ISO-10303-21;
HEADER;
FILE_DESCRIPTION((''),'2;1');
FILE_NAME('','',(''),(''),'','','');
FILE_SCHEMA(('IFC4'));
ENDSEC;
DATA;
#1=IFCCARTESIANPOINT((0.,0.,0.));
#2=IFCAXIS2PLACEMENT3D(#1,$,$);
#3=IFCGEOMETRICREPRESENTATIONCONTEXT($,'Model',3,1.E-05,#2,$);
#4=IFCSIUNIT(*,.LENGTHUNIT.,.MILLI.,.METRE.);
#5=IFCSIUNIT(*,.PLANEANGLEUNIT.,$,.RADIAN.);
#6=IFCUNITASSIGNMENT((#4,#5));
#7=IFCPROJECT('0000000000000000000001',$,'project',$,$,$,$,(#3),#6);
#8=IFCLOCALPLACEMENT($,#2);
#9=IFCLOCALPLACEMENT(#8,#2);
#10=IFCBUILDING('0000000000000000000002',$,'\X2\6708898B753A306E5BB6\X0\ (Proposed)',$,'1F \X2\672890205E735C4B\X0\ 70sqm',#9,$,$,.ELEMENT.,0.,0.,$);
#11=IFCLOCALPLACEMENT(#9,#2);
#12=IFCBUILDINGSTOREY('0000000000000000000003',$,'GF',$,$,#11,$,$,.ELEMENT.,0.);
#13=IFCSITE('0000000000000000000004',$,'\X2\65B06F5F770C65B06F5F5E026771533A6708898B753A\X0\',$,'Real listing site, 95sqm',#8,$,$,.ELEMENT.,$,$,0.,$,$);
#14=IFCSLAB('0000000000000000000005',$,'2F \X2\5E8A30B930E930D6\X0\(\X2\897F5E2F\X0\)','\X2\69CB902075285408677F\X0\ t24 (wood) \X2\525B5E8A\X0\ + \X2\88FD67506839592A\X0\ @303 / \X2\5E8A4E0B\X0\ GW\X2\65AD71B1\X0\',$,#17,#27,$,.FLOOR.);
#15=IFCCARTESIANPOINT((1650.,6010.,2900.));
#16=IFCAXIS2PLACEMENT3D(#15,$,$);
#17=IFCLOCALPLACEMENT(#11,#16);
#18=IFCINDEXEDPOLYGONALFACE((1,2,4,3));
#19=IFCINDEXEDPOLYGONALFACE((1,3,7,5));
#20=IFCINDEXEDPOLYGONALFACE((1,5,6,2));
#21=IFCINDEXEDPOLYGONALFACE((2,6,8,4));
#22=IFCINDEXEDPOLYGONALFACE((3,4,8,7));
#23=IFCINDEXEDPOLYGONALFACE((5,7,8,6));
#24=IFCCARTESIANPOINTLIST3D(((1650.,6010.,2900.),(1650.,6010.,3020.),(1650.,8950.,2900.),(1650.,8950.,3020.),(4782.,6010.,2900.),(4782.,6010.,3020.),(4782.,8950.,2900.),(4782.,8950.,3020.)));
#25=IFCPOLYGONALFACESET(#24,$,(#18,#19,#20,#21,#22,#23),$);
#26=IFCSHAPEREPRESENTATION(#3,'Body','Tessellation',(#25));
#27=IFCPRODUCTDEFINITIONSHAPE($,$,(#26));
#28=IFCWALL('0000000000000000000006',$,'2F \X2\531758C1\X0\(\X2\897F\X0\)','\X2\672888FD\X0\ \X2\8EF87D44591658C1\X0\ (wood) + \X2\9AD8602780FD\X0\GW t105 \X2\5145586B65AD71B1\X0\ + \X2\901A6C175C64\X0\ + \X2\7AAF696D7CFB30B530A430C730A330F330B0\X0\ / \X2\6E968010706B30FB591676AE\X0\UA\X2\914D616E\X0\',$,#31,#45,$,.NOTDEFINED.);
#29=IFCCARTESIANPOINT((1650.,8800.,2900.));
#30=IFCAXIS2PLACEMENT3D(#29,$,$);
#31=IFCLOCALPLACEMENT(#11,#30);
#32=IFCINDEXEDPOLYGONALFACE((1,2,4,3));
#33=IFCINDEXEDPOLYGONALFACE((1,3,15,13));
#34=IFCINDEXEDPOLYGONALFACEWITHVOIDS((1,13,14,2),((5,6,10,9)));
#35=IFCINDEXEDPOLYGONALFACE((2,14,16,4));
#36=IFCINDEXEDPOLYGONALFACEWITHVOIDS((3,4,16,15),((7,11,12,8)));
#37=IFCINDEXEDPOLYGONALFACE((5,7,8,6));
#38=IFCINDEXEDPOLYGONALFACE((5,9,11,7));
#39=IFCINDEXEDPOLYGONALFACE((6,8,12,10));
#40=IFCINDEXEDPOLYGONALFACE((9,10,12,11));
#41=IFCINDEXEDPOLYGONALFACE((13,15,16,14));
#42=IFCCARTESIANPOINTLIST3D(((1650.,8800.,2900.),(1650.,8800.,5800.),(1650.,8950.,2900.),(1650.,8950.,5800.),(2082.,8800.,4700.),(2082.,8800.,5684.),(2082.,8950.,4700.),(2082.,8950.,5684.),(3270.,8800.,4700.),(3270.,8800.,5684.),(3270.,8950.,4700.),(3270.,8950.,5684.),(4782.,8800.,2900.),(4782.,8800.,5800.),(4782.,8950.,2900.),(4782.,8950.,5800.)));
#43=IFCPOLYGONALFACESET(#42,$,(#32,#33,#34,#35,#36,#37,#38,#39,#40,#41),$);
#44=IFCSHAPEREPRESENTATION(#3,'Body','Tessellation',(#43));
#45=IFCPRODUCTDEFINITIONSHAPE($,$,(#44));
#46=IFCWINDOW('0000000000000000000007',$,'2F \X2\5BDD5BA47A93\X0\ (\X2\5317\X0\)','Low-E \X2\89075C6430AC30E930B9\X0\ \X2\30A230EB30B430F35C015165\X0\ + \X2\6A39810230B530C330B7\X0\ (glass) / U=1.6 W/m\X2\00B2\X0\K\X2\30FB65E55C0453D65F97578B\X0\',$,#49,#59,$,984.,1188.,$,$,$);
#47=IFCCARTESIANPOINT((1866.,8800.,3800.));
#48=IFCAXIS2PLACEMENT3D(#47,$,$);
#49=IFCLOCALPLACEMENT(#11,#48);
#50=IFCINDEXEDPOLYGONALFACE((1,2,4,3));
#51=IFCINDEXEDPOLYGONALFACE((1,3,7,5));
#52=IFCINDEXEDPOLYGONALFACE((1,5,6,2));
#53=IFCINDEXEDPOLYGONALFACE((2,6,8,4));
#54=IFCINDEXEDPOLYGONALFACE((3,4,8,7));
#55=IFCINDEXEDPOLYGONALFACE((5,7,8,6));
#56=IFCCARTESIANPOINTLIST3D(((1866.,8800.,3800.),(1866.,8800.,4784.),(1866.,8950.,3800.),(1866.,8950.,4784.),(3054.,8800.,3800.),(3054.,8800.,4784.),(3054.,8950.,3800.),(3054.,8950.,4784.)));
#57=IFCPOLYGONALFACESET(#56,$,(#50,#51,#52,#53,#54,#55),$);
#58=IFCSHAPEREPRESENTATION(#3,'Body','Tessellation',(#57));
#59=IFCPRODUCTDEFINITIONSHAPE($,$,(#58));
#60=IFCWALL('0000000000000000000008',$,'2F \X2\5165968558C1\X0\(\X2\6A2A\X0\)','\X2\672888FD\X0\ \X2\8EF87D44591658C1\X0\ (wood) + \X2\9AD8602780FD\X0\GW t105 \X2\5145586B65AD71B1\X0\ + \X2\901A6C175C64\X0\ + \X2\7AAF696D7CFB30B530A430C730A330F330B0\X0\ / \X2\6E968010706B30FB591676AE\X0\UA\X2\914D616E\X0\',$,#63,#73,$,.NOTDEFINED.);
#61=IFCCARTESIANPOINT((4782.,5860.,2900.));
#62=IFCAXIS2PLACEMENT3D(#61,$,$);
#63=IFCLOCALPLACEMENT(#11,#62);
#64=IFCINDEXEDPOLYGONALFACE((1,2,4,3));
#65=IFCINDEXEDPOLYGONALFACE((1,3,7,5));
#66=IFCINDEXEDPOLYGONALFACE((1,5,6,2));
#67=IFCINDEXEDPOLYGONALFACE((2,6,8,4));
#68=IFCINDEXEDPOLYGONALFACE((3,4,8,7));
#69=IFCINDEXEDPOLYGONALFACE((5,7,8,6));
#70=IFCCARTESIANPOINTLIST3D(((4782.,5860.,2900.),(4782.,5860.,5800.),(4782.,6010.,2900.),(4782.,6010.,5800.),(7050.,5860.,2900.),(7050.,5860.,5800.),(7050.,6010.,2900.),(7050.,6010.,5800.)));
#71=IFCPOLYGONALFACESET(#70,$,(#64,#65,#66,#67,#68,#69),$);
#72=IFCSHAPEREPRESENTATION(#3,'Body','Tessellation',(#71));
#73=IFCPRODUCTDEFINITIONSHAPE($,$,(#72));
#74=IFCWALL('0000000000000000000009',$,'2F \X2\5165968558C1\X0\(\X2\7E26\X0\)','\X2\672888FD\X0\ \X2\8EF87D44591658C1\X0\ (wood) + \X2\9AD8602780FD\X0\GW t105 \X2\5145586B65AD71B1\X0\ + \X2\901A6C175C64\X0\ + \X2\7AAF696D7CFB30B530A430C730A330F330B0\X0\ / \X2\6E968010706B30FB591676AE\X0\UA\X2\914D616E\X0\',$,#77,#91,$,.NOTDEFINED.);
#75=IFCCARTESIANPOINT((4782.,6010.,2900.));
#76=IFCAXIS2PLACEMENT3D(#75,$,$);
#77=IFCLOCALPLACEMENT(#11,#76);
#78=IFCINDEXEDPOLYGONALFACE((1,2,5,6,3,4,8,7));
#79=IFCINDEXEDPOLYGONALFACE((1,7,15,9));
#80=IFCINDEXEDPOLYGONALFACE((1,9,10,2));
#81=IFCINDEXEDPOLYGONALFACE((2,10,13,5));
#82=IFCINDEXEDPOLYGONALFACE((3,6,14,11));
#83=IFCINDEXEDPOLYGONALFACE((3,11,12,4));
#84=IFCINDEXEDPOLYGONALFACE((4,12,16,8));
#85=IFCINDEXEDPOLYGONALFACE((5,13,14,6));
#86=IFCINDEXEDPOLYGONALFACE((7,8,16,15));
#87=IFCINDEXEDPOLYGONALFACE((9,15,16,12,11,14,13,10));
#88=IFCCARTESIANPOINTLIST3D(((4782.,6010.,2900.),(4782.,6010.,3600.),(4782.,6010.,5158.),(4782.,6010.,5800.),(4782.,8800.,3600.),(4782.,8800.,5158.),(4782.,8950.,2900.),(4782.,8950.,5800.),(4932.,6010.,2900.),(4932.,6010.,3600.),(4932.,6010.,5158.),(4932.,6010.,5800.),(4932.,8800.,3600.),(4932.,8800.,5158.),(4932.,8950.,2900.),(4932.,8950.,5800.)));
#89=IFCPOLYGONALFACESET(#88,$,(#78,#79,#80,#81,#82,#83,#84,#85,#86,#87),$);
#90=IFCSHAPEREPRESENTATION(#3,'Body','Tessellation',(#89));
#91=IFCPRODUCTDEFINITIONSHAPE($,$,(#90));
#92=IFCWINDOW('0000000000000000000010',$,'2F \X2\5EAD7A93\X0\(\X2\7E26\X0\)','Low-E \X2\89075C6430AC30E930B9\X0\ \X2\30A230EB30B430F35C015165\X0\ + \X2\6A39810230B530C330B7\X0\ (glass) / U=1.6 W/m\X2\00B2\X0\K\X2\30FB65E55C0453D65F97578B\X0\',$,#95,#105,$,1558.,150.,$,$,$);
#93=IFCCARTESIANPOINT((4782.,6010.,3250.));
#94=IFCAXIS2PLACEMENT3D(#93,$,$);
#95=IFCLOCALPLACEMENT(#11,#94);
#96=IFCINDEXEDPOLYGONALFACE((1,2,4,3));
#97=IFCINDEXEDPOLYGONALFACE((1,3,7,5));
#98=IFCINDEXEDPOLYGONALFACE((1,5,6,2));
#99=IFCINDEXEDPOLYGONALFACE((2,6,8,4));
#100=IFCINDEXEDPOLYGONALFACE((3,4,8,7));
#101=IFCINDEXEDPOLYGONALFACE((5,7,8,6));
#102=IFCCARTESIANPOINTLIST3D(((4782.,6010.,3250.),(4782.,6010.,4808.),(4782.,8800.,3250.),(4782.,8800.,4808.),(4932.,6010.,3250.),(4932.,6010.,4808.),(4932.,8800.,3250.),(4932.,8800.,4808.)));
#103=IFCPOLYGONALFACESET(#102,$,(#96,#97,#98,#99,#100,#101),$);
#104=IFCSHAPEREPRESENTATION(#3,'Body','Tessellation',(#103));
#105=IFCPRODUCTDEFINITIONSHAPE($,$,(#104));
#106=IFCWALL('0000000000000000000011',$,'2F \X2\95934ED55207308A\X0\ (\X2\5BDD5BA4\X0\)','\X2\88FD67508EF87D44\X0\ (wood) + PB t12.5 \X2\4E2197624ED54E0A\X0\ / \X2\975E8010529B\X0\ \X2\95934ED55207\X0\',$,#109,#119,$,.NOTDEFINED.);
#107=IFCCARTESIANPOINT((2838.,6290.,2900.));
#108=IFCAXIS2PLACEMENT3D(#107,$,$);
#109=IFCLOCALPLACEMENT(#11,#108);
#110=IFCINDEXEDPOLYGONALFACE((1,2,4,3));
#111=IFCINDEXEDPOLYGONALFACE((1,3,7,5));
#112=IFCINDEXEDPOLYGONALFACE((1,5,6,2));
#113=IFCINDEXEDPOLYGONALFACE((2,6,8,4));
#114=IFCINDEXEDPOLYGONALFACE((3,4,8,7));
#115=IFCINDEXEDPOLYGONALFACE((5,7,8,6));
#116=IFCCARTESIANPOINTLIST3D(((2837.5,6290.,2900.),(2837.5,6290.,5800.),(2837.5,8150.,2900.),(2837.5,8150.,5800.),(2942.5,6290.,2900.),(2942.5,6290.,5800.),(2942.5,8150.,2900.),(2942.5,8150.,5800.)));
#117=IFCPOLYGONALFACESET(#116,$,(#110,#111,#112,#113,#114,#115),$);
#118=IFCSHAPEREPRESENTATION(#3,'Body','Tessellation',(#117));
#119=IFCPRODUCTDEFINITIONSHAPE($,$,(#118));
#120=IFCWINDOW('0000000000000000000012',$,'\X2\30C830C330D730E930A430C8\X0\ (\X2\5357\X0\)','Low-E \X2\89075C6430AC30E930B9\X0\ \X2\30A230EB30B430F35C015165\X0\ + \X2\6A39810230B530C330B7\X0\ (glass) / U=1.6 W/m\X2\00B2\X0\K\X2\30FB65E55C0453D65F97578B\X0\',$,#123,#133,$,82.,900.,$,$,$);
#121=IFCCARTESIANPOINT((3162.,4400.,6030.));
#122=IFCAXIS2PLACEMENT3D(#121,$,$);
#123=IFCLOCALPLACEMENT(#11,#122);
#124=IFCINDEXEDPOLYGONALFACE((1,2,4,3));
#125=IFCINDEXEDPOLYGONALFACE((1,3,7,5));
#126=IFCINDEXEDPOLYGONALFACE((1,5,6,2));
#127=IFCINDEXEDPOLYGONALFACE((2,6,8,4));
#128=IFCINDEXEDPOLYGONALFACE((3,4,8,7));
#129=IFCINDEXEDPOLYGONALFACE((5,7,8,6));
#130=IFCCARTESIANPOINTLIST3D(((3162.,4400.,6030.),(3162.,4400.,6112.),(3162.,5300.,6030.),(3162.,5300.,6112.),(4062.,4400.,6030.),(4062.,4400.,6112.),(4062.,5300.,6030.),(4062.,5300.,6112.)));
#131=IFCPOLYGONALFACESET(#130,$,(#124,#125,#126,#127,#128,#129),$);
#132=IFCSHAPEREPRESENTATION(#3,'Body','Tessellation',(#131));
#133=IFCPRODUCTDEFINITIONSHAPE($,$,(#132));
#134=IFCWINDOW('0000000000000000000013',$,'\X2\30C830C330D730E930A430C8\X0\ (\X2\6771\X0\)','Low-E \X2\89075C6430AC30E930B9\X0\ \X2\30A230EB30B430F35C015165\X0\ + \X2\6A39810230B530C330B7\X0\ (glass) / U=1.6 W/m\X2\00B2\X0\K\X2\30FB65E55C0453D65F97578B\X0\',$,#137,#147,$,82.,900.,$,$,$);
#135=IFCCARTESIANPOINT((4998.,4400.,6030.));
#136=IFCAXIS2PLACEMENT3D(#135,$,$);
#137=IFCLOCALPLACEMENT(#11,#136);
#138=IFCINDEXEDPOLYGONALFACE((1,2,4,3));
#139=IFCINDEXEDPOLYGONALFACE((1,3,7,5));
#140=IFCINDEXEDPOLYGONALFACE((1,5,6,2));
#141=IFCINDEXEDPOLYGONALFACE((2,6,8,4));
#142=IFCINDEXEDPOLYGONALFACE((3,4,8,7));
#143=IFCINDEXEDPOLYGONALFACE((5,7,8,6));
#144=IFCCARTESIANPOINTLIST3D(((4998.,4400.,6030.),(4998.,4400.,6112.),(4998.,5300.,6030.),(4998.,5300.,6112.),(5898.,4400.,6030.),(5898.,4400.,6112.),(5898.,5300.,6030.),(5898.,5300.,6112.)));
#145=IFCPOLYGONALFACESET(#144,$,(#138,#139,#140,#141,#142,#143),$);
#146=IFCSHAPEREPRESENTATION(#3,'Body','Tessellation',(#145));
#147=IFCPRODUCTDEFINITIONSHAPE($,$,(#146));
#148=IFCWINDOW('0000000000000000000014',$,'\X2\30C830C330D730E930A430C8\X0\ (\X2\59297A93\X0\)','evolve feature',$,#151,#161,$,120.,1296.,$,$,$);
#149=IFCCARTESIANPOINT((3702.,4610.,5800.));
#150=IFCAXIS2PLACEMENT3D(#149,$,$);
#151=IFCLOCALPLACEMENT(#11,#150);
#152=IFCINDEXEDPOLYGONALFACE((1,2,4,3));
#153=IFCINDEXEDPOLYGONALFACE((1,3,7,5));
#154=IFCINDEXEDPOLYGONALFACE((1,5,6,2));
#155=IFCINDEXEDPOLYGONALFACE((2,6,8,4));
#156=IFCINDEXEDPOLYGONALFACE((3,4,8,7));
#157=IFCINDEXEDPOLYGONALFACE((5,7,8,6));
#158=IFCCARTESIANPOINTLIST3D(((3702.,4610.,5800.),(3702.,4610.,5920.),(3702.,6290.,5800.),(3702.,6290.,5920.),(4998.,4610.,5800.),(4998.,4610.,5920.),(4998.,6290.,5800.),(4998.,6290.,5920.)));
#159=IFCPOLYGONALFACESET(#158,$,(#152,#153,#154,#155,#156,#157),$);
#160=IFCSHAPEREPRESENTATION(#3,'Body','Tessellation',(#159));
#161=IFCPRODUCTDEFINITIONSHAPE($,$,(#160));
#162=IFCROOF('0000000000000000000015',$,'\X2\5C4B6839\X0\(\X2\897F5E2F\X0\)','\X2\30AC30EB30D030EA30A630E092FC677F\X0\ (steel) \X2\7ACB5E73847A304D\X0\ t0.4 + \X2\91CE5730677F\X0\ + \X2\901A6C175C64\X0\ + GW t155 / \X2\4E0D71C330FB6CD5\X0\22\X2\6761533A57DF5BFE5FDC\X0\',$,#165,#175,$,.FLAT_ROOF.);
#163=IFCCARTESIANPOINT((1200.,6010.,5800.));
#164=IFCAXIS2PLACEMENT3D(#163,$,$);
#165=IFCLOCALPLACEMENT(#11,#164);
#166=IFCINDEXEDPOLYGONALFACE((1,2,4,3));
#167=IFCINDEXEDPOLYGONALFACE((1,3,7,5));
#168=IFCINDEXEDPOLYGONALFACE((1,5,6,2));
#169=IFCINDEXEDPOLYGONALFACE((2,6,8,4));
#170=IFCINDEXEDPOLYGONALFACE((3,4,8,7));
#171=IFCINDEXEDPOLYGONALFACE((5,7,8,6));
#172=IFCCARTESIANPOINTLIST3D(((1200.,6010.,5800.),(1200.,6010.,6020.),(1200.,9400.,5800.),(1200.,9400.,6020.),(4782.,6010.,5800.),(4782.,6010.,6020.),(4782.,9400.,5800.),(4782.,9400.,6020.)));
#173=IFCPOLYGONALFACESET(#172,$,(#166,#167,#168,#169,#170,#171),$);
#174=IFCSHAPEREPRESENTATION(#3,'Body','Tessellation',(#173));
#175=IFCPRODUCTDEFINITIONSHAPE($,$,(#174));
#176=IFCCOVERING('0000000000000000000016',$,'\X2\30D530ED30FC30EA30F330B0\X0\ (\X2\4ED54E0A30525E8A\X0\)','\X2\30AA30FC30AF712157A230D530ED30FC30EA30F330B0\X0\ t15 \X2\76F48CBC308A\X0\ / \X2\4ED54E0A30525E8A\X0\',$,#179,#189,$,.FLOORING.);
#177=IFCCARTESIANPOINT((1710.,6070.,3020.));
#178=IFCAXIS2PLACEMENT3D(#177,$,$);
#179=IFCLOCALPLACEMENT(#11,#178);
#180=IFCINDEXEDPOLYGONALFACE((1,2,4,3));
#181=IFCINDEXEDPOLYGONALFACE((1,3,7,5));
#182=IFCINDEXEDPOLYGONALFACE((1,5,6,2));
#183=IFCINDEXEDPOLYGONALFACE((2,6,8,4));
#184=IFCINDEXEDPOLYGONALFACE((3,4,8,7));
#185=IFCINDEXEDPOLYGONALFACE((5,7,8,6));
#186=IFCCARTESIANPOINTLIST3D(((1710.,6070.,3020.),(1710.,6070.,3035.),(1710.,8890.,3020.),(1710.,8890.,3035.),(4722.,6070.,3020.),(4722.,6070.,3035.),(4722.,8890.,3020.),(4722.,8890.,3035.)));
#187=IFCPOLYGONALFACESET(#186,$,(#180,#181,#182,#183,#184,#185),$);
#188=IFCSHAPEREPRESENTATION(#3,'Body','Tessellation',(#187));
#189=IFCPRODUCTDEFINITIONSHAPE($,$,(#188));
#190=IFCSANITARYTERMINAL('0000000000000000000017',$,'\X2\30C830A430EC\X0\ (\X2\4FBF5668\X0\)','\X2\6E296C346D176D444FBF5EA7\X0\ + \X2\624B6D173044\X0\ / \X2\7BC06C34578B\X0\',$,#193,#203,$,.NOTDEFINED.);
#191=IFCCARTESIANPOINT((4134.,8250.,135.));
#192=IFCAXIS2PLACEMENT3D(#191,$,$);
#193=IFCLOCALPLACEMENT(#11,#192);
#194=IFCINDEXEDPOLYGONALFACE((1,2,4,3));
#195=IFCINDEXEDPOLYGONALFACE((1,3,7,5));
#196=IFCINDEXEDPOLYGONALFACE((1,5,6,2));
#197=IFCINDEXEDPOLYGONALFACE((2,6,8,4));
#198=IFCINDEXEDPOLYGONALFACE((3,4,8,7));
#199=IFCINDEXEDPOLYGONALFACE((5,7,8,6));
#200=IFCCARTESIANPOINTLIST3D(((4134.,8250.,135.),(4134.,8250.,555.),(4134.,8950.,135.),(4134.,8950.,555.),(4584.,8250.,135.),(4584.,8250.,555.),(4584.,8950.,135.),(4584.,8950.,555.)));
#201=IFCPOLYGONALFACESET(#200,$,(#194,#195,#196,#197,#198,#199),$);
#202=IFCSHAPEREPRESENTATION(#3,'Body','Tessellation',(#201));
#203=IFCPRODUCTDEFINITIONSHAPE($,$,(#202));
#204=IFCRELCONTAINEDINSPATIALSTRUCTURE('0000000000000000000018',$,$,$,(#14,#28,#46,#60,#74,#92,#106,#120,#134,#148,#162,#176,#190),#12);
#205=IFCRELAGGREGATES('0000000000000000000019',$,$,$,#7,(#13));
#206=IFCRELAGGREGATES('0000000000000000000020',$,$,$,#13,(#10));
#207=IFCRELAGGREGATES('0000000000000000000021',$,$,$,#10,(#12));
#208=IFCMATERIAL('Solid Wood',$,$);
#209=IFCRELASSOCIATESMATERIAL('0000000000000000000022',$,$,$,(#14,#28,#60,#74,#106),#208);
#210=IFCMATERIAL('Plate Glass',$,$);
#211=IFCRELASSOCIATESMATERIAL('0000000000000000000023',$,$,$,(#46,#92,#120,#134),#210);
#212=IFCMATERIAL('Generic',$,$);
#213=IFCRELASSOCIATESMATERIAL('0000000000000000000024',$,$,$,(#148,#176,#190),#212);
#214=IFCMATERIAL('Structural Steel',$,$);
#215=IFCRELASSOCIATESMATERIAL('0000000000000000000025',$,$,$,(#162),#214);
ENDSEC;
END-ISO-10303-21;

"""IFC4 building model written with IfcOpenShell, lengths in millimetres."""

from ifc_helpers import new_model, si_unit, frame, frame_2d, origin, place, context, project, spatial, rectangle, extrude, material, element, fill, save


model = new_model("IFC4")

# Units and contexts
model_context = context("Model", 3, precision=1e-05, world=origin())
ifc_project = project(units=[si_unit("LENGTHUNIT", "METRE", prefix="MILLI"), si_unit("PLANEANGLEUNIT", "RADIAN")], contexts=[model_context])

# Site, building, storey
site_placement = place(None, origin())
site = spatial("IfcSite", under=ifc_project, at=site_placement, Name="新潟県新潟市東区月見町", ObjectType="Real listing site, 95sqm", CompositionType="ELEMENT", RefElevation=0.0)
building_placement = place(site_placement, origin())
building = spatial("IfcBuilding", under=site, at=building_placement, Name="月見町の家 (Proposed)", ObjectType="1F 木造平屋 70sqm", CompositionType="ELEMENT", ElevationOfRefHeight=0.0, ElevationOfTerrain=0.0)
storey_placement = place(building_placement, origin())
storey = spatial("IfcBuildingStorey", under=building, at=storey_placement, Name="GF", CompositionType="ELEMENT", Elevation=0.0)

# Slab
ifc_material_1 = material(Name="Solid Wood")
slab_placement = place(storey_placement, frame((1650.0, 6010.0, 2900.0)))
element("IfcSlab", 1, at=slab_placement, inside=storey, material=ifc_material_1, Name="2F 床スラブ(西帯)", Description="構造用合板 t24 (wood) 剛床 + 製材根太 @303 / 床下 GW断熱", PredefinedType="FLOOR", context=model_context, shape_type="SweptSolid", body=[
    extrude(rectangle(XDim=3132.0, YDim=2940.0, at=frame_2d((1566.0, 1470.0))), frame((1650.0, 6010.0, 2900.0)), (0.0, 0.0, 1.0), 120.0),
])

# Wall, opening, window
wall_1_placement = place(storey_placement, frame((1650.0, 8800.0, 2900.0)))
wall_1 = element("IfcWall", 2, at=wall_1_placement, inside=storey, material=ifc_material_1, Name="2F 北壁(西)", Description="木製 軸組外壁 (wood) + 高性能GW t105 充填断熱 + 通気層 + 窯業系サイディング / 準耐火・外皮UA配慮", PredefinedType="NOTDEFINED", context=model_context, shape_type="SweptSolid", body=[
    extrude(rectangle(XDim=3132.0, YDim=150.0, at=frame_2d((1566.0, 75.0))), frame((1650.0, 8800.0, 2900.0)), (0.0, 0.0, 1.0), 2900.0),
])
opening_1_placement = place(storey_placement, frame((1866.0, 8800.0, 3800.0)))
opening_1 = element("IfcOpeningElement", 3, at=opening_1_placement, cuts=wall_1, PredefinedType="NOTDEFINED", context=model_context, shape_type="SweptSolid", body=[
    extrude(rectangle(XDim=1188.0, YDim=150.0, at=frame_2d((594.0, 75.0))), frame((1866.0, 8800.0, 3800.0)), (0.0, 0.0, 1.0), 984.0),
])
ifc_material_2 = material(Name="Plate Glass")
window_1_placement = place(storey_placement, frame((1866.0, 8800.0, 3800.0)))
window_1 = element("IfcWindow", 4, at=window_1_placement, inside=storey, material=ifc_material_2, Name="2F 寝室窓 (北)", Description="Low-E 複層ガラス アルゴン封入 + 樹脂サッシ (glass) / U=1.6 W/m²K・日射取得型", OverallHeight=984.0, OverallWidth=1188.0, context=model_context, shape_type="SweptSolid", body=[
    extrude(rectangle(XDim=1188.0, YDim=150.0, at=frame_2d((594.0, 75.0))), frame((1866.0, 8800.0, 3800.0)), (0.0, 0.0, 1.0), 984.0),
])
fill(opening_1, window_1)

# Wall
wall_2_placement = place(storey_placement, frame((4782.0, 5860.0, 2900.0)))
element("IfcWall", 5, at=wall_2_placement, inside=storey, material=ifc_material_1, Name="2F 入隅壁(横)", Description="木製 軸組外壁 (wood) + 高性能GW t105 充填断熱 + 通気層 + 窯業系サイディング / 準耐火・外皮UA配慮", PredefinedType="NOTDEFINED", context=model_context, shape_type="SweptSolid", body=[
    extrude(rectangle(XDim=2268.0, YDim=150.0, at=frame_2d((1134.0, 75.0))), frame((4782.0, 5860.0, 2900.0)), (0.0, 0.0, 1.0), 2900.0),
])

# Wall, opening, window
wall_3_placement = place(storey_placement, frame((4782.0, 6010.0, 2900.0)))
wall_3 = element("IfcWall", 6, at=wall_3_placement, inside=storey, material=ifc_material_1, Name="2F 入隅壁(縦)", Description="木製 軸組外壁 (wood) + 高性能GW t105 充填断熱 + 通気層 + 窯業系サイディング / 準耐火・外皮UA配慮", PredefinedType="NOTDEFINED", context=model_context, shape_type="SweptSolid", body=[
    extrude(rectangle(XDim=150.0, YDim=2940.0, at=frame_2d((75.0, 1470.0))), frame((4782.0, 6010.0, 2900.0)), (0.0, 0.0, 1.0), 2900.0),
])
opening_2_placement = place(storey_placement, frame((4782.0, 6010.0, 3250.0)))
opening_2 = element("IfcOpeningElement", 7, at=opening_2_placement, cuts=wall_3, PredefinedType="NOTDEFINED", context=model_context, shape_type="SweptSolid", body=[
    extrude(rectangle(XDim=150.0, YDim=2790.0, at=frame_2d((75.0, 1395.0))), frame((4782.0, 6010.0, 3250.0)), (0.0, 0.0, 1.0), 1558.0),
])
window_2_placement = place(storey_placement, frame((4782.0, 6010.0, 3250.0)))
window_2 = element("IfcWindow", 8, at=window_2_placement, inside=storey, material=ifc_material_2, Name="2F 庭窓(縦)", Description="Low-E 複層ガラス アルゴン封入 + 樹脂サッシ (glass) / U=1.6 W/m²K・日射取得型", OverallHeight=1558.0, OverallWidth=150.0, context=model_context, shape_type="SweptSolid", body=[
    extrude(rectangle(XDim=150.0, YDim=2790.0, at=frame_2d((75.0, 1395.0))), frame((4782.0, 6010.0, 3250.0)), (0.0, 0.0, 1.0), 1558.0),
])
fill(opening_2, window_2)

# Wall
wall_4_placement = place(storey_placement, frame((2838.0, 6290.0, 2900.0)))
element("IfcWall", 9, at=wall_4_placement, inside=storey, material=ifc_material_1, Name="2F 間仕切り (寝室)", Description="製材軸組 (wood) + PB t12.5 両面仕上 / 非耐力 間仕切", PredefinedType="NOTDEFINED", context=model_context, shape_type="SweptSolid", body=[
    extrude(rectangle(XDim=105.0, YDim=1860.0, at=frame_2d((52.0, 930.0))), frame((2838.0, 6290.0, 2900.0)), (0.0, 0.0, 1.0), 2900.0),
])

# Windows
window_3_placement = place(storey_placement, frame((3162.0, 4400.0, 6030.0)))
element("IfcWindow", 10, at=window_3_placement, inside=storey, material=ifc_material_2, Name="トップライト (南)", Description="Low-E 複層ガラス アルゴン封入 + 樹脂サッシ (glass) / U=1.6 W/m²K・日射取得型", OverallHeight=82.0, OverallWidth=900.0, context=model_context, shape_type="SweptSolid", body=[
    extrude(rectangle(XDim=900.0, YDim=900.0, at=frame_2d((450.0, 450.0))), frame((3162.0, 4400.0, 6030.0)), (0.0, 0.0, 1.0), 82.0),
])
window_4_placement = place(storey_placement, frame((4998.0, 4400.0, 6030.0)))
element("IfcWindow", 11, at=window_4_placement, inside=storey, material=ifc_material_2, Name="トップライト (東)", Description="Low-E 複層ガラス アルゴン封入 + 樹脂サッシ (glass) / U=1.6 W/m²K・日射取得型", OverallHeight=82.0, OverallWidth=900.0, context=model_context, shape_type="SweptSolid", body=[
    extrude(rectangle(XDim=900.0, YDim=900.0, at=frame_2d((450.0, 450.0))), frame((4998.0, 4400.0, 6030.0)), (0.0, 0.0, 1.0), 82.0),
])
ifc_material_3 = material(Name="Generic")
window_5_placement = place(storey_placement, frame((3702.0, 4610.0, 5800.0)))
element("IfcWindow", 12, at=window_5_placement, inside=storey, material=ifc_material_3, Name="トップライト (天窓)", Description="evolve feature", OverallHeight=120.0, OverallWidth=1296.0, context=model_context, shape_type="SweptSolid", body=[
    extrude(rectangle(XDim=1296.0, YDim=1680.0, at=frame_2d((648.0, 840.0))), frame((3702.0, 4610.0, 5800.0)), (0.0, 0.0, 1.0), 120.0),
])

# Roof
ifc_material_4 = material(Name="Structural Steel")
for number, where, name in (
    (13, (1200.0, 6010.0, 5800.0), "屋根(西帯)"),
):
    element("IfcRoof", number, at=place(storey_placement, frame(where)), inside=storey, material=ifc_material_4, Name=name, Description="ガルバリウム鋼板 (steel) 立平葺き t0.4 + 野地板 + 通気層 + GW t155 / 不燃・法22条区域対応", PredefinedType="FLAT_ROOF", context=model_context, shape_type="SweptSolid", body=[
        extrude(rectangle(XDim=3582.0, YDim=3390.0, at=frame_2d((1791.0, 1695.0))), frame((1200.0, 6010.0, 5800.0)), (0.0, 0.0, 1.0), 220.0),
    ])

# Covering
covering_placement = place(storey_placement, frame((1710.0, 6070.0, 3020.0)))
element("IfcCovering", 14, at=covering_placement, inside=storey, material=ifc_material_3, Name="フローリング (仕上げ床)", Description="オーク無垢フローリング t15 直貼り / 仕上げ床", PredefinedType="FLOORING", context=model_context, shape_type="SweptSolid", body=[
    extrude(rectangle(XDim=3012.0, YDim=2820.0, at=frame_2d((1506.0, 1410.0))), frame((1710.0, 6070.0, 3020.0)), (0.0, 0.0, 1.0), 15.0),
])

# Sanitary terminal
sanitary_terminal_placement = place(storey_placement, frame((4134.0, 8250.0, 135.0)))
element("IfcSanitaryTerminal", 15, at=sanitary_terminal_placement, inside=storey, material=ifc_material_3, Name="トイレ (便器)", Description="温水洗浄便座 + 手洗い / 節水型", PredefinedType="NOTDEFINED", context=model_context, shape_type="SweptSolid", body=[
    extrude(rectangle(XDim=450.0, YDim=700.0, at=frame_2d((225.0, 350.0))), frame((4134.0, 8250.0, 135.0)), (0.0, 0.0, 1.0), 420.0),
])

save(model, "model.ifc")
